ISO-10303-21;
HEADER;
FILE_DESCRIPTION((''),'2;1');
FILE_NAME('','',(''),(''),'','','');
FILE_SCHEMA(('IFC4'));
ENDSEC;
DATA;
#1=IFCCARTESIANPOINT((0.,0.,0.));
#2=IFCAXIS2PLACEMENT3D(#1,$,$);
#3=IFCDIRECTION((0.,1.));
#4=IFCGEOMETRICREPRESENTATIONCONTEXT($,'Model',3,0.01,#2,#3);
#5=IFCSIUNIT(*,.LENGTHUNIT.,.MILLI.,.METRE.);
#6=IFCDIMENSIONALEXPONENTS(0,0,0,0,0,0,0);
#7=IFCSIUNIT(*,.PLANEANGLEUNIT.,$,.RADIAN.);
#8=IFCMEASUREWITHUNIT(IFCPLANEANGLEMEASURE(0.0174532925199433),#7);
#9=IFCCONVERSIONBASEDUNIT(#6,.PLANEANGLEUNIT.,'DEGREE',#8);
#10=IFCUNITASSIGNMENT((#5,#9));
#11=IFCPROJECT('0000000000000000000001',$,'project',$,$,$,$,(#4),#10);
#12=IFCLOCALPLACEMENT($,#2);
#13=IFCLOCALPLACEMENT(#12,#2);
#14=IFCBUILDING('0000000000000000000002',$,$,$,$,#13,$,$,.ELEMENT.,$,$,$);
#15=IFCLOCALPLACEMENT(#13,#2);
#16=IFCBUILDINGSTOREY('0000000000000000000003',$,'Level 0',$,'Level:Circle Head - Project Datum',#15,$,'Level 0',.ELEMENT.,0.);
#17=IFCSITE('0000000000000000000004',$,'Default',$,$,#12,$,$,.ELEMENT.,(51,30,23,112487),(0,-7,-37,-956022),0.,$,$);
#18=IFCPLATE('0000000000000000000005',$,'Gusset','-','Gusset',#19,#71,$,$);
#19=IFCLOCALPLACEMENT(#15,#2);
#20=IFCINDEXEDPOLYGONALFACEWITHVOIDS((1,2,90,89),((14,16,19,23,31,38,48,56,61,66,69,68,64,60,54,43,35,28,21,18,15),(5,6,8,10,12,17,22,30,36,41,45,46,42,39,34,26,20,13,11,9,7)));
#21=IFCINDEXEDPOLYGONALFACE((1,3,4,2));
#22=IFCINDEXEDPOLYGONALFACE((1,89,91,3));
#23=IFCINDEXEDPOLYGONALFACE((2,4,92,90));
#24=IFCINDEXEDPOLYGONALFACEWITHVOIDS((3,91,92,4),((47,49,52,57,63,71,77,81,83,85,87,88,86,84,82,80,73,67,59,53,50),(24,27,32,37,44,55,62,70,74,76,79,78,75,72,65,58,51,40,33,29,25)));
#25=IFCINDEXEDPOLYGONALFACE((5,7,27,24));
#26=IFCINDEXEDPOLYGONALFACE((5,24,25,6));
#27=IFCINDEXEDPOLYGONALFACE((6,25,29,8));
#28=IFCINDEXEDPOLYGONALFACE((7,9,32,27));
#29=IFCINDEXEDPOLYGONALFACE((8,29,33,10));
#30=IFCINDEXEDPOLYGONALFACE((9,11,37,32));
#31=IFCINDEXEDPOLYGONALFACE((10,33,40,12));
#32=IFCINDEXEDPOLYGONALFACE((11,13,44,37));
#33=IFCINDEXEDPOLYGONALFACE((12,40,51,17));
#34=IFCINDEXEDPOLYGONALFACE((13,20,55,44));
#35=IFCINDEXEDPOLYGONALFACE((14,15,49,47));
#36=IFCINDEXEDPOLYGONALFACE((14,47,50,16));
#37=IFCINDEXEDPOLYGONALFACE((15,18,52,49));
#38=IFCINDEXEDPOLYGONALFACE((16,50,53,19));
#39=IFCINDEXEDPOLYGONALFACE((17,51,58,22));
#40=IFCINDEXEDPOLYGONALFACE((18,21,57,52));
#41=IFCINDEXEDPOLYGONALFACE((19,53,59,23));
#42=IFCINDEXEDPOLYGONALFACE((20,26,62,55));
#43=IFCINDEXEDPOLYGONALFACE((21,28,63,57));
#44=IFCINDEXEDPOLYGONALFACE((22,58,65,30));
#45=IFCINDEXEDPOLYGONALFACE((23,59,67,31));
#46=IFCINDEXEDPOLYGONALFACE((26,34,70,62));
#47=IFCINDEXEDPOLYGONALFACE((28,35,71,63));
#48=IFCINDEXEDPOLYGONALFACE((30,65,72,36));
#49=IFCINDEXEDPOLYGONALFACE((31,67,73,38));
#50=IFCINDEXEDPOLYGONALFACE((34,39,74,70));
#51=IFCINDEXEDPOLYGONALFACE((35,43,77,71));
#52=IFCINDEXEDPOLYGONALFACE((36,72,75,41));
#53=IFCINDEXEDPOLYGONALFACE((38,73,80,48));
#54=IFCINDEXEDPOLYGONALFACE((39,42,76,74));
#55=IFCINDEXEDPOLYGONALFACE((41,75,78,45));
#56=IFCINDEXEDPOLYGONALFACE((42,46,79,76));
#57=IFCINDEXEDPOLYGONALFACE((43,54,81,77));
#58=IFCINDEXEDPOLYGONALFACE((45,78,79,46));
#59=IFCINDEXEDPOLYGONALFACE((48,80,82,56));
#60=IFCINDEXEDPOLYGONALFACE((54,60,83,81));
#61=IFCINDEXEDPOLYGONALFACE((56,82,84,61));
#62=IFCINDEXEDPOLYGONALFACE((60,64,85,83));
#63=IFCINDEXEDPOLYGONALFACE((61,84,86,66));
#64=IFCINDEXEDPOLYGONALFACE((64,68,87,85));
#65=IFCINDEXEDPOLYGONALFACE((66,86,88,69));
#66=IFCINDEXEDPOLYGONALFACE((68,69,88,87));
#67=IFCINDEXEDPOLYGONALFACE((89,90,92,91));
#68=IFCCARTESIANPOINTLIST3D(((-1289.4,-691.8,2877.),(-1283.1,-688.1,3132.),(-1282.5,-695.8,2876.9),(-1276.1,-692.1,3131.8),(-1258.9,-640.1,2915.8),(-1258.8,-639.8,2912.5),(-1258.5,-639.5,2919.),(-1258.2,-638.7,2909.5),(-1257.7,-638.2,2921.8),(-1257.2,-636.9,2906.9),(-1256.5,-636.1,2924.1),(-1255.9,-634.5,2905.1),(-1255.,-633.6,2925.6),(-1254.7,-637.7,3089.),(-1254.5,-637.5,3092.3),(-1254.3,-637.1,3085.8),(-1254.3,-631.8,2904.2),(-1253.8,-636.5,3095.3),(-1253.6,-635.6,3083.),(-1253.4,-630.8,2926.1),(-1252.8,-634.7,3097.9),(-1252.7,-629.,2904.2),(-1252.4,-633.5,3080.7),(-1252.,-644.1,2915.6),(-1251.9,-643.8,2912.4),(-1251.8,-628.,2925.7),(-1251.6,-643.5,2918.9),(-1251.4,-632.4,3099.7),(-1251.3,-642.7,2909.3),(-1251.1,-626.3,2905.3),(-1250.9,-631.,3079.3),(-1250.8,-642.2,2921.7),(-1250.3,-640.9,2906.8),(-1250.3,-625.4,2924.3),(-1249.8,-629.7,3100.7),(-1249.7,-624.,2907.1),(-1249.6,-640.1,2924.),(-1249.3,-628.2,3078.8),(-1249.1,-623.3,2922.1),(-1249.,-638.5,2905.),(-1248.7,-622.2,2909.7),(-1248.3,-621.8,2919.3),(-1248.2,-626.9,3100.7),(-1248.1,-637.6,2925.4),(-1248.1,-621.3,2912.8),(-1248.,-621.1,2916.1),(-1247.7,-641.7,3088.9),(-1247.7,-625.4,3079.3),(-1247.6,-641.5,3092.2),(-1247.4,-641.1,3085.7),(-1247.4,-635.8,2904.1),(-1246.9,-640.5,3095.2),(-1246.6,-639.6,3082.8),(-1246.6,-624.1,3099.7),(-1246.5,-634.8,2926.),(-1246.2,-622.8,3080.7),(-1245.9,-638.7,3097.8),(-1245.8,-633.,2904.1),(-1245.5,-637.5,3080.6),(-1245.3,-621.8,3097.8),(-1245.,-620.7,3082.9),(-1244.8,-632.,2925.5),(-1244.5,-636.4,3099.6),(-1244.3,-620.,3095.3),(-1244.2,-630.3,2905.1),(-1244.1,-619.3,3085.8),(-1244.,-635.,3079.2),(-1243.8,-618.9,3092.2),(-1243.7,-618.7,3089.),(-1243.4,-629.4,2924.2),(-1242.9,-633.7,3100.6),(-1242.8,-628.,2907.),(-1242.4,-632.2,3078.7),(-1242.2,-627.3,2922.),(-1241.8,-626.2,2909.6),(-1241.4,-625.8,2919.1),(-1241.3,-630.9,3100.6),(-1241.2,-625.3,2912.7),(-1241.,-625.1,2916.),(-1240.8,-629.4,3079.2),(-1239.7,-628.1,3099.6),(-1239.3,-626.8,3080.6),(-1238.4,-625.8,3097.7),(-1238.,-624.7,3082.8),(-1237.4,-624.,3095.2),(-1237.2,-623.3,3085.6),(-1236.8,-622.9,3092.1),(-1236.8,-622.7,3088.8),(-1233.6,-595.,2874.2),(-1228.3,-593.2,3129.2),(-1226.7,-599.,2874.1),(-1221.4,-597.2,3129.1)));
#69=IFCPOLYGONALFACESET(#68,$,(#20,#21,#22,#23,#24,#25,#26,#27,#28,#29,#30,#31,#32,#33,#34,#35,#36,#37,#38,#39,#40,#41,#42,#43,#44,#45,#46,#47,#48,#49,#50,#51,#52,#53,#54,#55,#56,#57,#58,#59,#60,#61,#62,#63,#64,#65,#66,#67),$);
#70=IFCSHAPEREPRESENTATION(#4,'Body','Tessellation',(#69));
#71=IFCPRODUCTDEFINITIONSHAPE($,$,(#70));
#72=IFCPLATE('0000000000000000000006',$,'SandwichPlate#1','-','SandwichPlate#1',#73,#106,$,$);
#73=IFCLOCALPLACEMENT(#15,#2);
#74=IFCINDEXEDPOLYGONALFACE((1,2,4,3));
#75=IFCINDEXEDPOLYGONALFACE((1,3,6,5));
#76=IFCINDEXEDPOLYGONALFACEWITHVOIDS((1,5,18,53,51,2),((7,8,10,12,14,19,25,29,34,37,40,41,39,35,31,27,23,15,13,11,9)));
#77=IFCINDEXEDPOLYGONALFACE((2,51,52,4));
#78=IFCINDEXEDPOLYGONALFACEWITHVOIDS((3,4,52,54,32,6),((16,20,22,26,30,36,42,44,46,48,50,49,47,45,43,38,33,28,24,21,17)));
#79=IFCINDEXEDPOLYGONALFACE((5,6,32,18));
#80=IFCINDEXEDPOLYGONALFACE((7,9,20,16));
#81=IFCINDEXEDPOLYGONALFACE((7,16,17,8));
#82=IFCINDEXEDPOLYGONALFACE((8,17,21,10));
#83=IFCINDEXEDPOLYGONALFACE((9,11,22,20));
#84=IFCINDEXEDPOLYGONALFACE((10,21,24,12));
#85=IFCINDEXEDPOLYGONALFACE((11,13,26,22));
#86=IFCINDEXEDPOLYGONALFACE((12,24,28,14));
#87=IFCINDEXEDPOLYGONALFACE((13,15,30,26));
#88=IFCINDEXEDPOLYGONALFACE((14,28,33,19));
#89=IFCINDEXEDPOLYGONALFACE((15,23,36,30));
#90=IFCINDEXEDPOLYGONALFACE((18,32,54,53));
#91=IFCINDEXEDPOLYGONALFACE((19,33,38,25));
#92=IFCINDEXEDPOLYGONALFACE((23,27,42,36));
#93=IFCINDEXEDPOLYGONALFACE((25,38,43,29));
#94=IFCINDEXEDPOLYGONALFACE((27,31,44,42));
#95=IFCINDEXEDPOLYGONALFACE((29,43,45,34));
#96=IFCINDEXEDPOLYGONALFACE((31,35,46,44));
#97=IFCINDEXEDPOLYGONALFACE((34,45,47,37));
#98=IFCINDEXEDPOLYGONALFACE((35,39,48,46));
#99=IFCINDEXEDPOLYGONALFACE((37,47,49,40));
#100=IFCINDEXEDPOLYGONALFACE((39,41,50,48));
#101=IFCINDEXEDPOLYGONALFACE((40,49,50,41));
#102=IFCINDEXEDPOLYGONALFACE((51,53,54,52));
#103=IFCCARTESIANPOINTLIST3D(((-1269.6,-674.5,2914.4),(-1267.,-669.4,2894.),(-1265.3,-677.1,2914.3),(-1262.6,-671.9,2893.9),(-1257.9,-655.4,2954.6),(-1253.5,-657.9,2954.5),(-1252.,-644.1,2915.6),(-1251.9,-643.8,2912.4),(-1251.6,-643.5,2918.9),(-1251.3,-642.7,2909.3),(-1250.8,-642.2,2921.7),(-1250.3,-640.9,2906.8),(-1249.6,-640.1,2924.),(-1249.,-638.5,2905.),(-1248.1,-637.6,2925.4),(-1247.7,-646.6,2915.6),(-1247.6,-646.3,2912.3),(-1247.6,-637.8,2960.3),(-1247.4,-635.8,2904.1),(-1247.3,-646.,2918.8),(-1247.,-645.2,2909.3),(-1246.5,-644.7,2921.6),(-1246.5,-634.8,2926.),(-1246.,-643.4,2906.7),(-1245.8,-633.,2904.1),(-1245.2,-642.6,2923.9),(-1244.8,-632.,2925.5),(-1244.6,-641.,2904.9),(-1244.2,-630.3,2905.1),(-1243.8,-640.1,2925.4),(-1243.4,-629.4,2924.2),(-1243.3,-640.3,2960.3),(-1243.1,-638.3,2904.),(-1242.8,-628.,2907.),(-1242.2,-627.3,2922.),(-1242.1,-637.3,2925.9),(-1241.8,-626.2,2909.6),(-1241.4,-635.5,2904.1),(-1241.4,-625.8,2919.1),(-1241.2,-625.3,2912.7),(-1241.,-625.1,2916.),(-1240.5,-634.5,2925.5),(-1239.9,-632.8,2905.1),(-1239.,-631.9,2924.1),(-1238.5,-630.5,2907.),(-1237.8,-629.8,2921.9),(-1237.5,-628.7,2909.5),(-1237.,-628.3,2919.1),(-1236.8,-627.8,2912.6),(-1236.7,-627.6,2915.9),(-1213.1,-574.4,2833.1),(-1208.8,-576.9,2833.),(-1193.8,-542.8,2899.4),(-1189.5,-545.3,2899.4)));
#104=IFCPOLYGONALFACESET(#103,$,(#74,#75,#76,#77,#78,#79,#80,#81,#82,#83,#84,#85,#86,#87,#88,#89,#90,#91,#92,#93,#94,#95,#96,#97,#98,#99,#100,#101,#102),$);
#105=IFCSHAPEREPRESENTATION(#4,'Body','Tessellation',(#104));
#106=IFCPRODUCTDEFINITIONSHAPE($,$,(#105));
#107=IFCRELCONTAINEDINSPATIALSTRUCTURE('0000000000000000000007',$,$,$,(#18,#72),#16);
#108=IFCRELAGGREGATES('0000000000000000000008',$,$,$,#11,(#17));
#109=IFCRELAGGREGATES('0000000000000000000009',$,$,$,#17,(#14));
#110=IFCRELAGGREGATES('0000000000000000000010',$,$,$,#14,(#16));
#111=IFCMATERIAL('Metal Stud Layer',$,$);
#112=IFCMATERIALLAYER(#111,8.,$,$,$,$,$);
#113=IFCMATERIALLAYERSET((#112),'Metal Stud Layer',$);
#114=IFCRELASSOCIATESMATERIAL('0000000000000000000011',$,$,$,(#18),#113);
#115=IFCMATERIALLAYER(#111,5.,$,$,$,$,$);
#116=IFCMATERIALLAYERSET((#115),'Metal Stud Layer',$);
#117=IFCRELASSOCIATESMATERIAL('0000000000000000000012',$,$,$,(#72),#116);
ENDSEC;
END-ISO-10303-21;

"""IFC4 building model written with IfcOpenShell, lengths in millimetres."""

from ifc_helpers import new_model, entity, si_unit, converted_unit, direction, frame, origin, origin_with_axes, origin_2d_with_axis, place, context, project, spatial, polyline, circle, outline, extrude, material, layer, layer_set, element, save


model = new_model("IFC4")

# Units and contexts
model_context = context("Model", 3, precision=0.01, world=origin(), true_north=direction((0.0, 1.0)))
ifc_project = project(units=[si_unit("LENGTHUNIT", "METRE", prefix="MILLI"), converted_unit("PLANEANGLEUNIT", "DEGREE", entity("IfcPlaneAngleMeasure", 0.0174532925199433), si_unit("PLANEANGLEUNIT", "RADIAN"), dimensions=[0, 0, 0, 0, 0, 0, 0])], contexts=[model_context])

# Site, building, storey
site_placement = place(None, origin())
site = spatial("IfcSite", under=ifc_project, at=site_placement, Name="Default", CompositionType="ELEMENT", RefLatitude=(51, 30, 23, 112487), RefLongitude=(0, -7, -37, -956022), RefElevation=0.0)
building_placement = place(site_placement, origin())
building = spatial("IfcBuilding", under=site, at=building_placement, CompositionType="ELEMENT")
storey_placement = place(building_placement, origin())
storey = spatial("IfcBuildingStorey", under=building, at=storey_placement, Name="Level 0", ObjectType="Level:Circle Head - Project Datum", LongName="Level 0", CompositionType="ELEMENT", Elevation=0.0)

# Plates, openings
ifc_material_1 = material(Name="Metal Stud Layer")
ifc_layer_1 = layer(ifc_material_1, 8.0)
ifc_layer_set_1 = layer_set([ifc_layer_1], Name="Metal Stud Layer")
ifc_layer_2 = layer(ifc_material_1, 5.0)
ifc_layer_set_2 = layer_set([ifc_layer_2], Name="Metal Stud Layer")
plate_1_placement = place(storey_placement, frame((-1281.9, -686.2, 3131.9), z_axis=(0.865935, -0.499948, -0.014432), x_axis=(-0.02499, -0.014428, -0.999584)))
plate_1 = element("IfcPlate", 1, at=plate_1_placement, inside=storey, material=ifc_layer_set_1, Name="Gusset", Description="-", ObjectType="Gusset", context=model_context, shape_type="SweptSolid", body=[
    extrude(outline(polyline([(0.0, -2.3), (255.1, -2.3), (255.1, 109.5), (0.0, 107.4), (0.0, -2.3)])), origin_with_axes(), (0.0, 0.0, 1.0), 8.0),
])
opening_1_placement = place(plate_1_placement, frame((215.2, 67.8, 8.5), z_axis=(0.0, 0.0, -1.0), x_axis=(0.465435, 0.885082, 0.0)))
element("IfcOpeningElement", 2, at=opening_1_placement, cuts=plate_1, ObjectType="Opening", context=model_context, shape_type="SweptSolid", body=[
    extrude(circle(Radius=11.0, at=origin_2d_with_axis()), origin(), (0.0, 0.0, 1.0), 9.0),
])
opening_2_placement = place(plate_1_placement, frame((40.4, 67.6, 8.5), z_axis=(0.0, 0.0, -1.0), x_axis=(-0.519472, 0.854487, 0.0)))
element("IfcOpeningElement", 3, at=opening_2_placement, cuts=plate_1, ObjectType="Opening", context=model_context, shape_type="SweptSolid", body=[
    extrude(circle(Radius=11.0, at=origin_2d_with_axis()), origin(), (0.0, 0.0, 1.0), 9.0),
])
plate_2_placement = place(storey_placement, frame((-1269.1, -683.3, 2901.2), z_axis=(-0.865935, 0.499948, 0.014432), x_axis=(0.254617, 0.415806, 0.873084)))
plate_2 = element("IfcPlate", 4, at=plate_2_placement, inside=storey, material=ifc_layer_set_2, Name="SandwichPlate#1", Description="-", ObjectType="SandwichPlate#1", context=model_context, shape_type="SweptSolid", body=[
    extrude(outline(polyline([(0.0, 0.0), (76.0, 0.0), (76.0, 140.0), (0.0, 140.0), (0.0, 0.0)])), origin_with_axes(), (0.0, 0.0, 1.0), 5.0),
])
opening_3_placement = place(plate_2_placement, frame((0.0, 0.0, 0.0), z_axis=(0.0, 0.0, 1.0), x_axis=(1.0, 0.0, 0.0)))
element("IfcOpeningElement", 5, at=opening_3_placement, cuts=plate_2, ObjectType="Opening", context=model_context, shape_type="SweptSolid", body=[
    extrude(outline(polyline([(0.0, 0.0), (15.0, 0.0), (0.0, 15.0), (0.0, 0.0)])), origin(), (0.0, 0.0, 1.0), 5.0),
])
opening_4_placement = place(plate_2_placement, frame((0.0, 0.0, 0.0), z_axis=(0.0, 0.0, 1.0), x_axis=(1.0, 0.0, 0.0)))
element("IfcOpeningElement", 6, at=opening_4_placement, cuts=plate_2, ObjectType="Opening", context=model_context, shape_type="SweptSolid", body=[
    extrude(outline(polyline([(76.0, 0.0), (76.0, 15.0), (61.0, 0.0), (76.0, 0.0)])), origin(), (0.0, 0.0, 1.0), 5.0),
])
opening_5_placement = place(plate_2_placement, frame((38.0, 40.0, -0.5), z_axis=(0.0, 0.0, 1.0), x_axis=(0.0, 1.0, 0.0)))
element("IfcOpeningElement", 7, at=opening_5_placement, cuts=plate_2, ObjectType="Opening", context=model_context, shape_type="SweptSolid", body=[
    extrude(circle(Radius=11.0, at=origin_2d_with_axis()), origin(), (0.0, 0.0, 1.0), 6.0),
])

save(model, "model.ifc")
